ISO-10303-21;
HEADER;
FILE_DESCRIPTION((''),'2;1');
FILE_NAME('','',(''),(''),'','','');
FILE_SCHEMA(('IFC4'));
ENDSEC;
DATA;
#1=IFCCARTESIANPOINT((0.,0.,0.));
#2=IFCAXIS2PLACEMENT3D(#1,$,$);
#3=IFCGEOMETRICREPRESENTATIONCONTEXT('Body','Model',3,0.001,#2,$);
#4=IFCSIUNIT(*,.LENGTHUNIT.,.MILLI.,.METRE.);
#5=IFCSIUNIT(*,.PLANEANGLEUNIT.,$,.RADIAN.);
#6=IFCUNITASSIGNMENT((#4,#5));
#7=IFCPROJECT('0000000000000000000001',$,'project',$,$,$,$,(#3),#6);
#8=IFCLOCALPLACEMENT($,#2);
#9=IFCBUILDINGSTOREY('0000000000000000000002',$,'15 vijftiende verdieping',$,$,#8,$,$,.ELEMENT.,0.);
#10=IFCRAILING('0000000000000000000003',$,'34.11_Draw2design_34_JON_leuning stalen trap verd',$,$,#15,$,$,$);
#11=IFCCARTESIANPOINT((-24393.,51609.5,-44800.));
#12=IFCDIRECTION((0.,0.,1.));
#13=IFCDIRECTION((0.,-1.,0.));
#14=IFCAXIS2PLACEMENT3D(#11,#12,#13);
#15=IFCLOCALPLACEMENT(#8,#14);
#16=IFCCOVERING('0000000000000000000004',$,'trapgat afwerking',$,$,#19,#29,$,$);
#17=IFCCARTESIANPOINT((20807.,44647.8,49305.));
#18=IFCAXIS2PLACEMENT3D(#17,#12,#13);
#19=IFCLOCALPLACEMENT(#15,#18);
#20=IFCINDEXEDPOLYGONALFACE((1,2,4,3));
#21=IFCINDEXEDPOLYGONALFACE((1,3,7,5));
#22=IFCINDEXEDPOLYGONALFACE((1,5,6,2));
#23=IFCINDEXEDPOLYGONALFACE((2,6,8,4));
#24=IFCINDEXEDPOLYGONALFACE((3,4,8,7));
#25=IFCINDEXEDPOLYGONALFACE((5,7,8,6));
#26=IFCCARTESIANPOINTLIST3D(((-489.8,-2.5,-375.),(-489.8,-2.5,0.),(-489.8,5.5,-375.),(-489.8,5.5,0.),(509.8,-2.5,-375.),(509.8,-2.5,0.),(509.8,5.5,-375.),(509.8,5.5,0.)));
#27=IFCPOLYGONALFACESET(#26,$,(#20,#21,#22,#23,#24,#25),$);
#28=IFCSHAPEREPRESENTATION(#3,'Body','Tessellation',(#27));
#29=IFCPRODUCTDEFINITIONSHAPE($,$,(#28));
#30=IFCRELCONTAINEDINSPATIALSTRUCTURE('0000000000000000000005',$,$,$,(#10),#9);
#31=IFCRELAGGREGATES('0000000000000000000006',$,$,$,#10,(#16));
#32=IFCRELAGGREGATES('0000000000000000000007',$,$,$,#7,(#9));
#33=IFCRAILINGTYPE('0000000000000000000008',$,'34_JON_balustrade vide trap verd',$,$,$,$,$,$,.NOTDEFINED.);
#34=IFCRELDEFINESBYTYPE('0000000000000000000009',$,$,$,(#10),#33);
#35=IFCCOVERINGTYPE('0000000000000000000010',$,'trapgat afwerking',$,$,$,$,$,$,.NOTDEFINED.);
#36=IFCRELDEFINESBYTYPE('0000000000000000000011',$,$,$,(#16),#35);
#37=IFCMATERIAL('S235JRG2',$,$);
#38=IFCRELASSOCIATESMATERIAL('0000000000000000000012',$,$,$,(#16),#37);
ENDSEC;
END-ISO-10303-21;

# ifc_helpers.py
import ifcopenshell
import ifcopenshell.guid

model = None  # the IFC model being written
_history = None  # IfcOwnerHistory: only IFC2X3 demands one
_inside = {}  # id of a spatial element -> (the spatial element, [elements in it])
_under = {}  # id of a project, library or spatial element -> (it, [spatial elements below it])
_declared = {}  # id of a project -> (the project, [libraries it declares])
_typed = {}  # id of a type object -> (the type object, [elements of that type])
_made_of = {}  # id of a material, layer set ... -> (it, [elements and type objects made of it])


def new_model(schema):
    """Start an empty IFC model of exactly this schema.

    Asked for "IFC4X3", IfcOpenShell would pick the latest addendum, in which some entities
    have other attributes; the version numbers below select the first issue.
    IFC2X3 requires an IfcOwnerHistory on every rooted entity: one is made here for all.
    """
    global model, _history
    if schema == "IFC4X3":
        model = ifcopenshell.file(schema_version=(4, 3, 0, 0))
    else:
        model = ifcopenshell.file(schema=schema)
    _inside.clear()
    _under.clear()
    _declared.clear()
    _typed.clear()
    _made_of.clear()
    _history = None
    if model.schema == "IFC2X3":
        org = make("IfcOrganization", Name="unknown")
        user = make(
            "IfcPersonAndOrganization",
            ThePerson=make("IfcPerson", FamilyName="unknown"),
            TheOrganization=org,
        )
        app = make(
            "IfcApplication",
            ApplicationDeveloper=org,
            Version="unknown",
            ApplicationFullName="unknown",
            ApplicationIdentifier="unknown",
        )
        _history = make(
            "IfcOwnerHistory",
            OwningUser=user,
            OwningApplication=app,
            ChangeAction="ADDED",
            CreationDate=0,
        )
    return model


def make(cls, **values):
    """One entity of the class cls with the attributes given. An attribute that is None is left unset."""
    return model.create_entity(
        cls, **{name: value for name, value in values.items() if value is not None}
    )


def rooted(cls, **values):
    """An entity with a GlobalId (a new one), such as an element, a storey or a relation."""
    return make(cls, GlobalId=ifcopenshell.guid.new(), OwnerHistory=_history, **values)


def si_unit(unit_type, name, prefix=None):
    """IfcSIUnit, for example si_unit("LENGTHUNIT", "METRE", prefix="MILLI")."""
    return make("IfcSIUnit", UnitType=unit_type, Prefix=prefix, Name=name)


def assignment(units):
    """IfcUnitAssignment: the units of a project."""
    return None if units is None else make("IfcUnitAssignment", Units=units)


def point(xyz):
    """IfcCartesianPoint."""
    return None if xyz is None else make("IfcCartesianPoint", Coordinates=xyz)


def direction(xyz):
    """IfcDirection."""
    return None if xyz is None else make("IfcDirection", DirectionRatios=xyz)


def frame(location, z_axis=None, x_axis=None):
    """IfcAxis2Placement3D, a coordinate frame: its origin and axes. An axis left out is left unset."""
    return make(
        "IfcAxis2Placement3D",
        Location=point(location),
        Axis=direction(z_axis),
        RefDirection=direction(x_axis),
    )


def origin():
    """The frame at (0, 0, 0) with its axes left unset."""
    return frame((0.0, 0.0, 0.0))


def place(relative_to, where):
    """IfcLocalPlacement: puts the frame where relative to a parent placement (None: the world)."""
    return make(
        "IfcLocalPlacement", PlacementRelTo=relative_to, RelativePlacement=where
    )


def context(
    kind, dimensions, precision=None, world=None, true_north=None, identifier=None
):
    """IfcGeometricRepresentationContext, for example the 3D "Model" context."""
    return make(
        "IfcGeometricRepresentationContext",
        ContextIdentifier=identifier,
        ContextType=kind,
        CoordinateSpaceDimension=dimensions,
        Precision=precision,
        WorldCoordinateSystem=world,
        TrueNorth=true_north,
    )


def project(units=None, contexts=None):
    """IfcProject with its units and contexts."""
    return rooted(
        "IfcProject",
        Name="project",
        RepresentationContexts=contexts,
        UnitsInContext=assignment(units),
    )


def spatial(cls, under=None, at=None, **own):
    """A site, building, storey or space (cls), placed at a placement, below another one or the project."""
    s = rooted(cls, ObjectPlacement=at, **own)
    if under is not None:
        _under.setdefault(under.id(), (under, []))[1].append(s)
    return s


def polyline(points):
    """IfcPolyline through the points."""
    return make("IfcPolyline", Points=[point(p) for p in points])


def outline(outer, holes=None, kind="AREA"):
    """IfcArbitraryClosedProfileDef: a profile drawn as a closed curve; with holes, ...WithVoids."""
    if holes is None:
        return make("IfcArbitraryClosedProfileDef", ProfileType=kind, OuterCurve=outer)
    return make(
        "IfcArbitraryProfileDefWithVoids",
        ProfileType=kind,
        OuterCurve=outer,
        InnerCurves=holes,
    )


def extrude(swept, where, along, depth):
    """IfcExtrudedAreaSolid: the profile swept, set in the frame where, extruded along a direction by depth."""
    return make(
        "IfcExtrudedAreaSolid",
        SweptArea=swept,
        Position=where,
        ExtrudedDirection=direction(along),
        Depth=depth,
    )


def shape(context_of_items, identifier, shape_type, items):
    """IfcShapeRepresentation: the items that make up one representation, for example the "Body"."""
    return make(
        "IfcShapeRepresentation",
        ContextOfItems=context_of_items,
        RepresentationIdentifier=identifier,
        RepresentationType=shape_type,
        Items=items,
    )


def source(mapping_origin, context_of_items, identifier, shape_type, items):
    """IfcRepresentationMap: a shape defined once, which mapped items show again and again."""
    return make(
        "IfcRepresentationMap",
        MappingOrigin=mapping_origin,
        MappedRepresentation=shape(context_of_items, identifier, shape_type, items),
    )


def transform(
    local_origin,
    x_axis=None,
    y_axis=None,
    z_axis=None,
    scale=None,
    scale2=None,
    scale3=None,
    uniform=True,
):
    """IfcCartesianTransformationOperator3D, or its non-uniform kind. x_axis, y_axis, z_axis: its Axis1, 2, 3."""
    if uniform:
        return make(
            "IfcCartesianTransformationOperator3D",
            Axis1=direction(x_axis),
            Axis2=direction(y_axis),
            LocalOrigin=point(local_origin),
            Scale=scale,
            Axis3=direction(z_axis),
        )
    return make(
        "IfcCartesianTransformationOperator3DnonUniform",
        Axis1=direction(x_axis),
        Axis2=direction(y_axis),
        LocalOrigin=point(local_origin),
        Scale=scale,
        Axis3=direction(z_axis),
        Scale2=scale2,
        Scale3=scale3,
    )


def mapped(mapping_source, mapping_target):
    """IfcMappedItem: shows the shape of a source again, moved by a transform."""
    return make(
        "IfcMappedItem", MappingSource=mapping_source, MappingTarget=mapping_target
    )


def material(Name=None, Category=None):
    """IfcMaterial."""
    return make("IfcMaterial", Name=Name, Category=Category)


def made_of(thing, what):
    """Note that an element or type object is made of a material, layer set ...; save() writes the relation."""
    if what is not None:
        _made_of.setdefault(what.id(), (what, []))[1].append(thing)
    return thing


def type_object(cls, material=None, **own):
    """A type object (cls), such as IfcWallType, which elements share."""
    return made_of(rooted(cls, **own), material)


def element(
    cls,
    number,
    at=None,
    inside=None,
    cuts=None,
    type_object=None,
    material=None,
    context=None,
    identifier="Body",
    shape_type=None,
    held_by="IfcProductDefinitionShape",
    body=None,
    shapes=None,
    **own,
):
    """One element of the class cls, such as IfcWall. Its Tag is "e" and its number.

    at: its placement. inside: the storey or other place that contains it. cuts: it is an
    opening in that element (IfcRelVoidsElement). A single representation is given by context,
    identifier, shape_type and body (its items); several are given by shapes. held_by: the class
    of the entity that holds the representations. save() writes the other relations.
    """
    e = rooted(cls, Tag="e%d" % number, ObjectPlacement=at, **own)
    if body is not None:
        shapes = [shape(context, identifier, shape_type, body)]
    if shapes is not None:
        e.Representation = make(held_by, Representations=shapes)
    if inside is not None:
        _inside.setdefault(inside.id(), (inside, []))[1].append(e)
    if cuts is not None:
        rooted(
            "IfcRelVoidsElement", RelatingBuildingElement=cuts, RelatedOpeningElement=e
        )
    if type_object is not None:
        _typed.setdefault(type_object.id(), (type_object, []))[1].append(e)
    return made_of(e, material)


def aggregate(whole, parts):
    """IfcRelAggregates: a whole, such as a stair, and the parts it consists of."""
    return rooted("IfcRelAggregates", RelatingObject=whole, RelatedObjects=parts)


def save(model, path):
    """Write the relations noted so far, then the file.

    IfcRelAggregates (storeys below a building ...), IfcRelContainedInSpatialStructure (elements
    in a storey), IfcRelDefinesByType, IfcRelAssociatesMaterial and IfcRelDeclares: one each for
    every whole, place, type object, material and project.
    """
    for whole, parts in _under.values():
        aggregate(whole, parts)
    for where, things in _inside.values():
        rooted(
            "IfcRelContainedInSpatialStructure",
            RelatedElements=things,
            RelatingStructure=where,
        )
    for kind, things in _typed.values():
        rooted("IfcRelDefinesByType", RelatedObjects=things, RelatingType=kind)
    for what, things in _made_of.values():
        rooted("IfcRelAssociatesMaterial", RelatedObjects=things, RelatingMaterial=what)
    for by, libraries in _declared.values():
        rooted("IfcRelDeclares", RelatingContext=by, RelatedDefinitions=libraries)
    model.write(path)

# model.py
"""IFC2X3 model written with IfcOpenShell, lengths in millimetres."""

from ifc_helpers import new_model, si_unit, frame, origin, place, context, project, spatial, polyline, outline, extrude, source, transform, mapped, material, type_object, element, aggregate, save


model = new_model("IFC2X3")

# Units and contexts
model_context = context("Model", 3, precision=0.001, world=origin(), identifier="Body")
ifc_project = project(units=[si_unit("LENGTHUNIT", "METRE", prefix="MILLI"), si_unit("PLANEANGLEUNIT", "RADIAN")], contexts=[model_context])

# Storey
storey_placement = place(None, origin())
storey = spatial("IfcBuildingStorey", under=ifc_project, at=storey_placement, Name="15 vijftiende verdieping", CompositionType="ELEMENT", Elevation=0.0)

# Railing, covering
railing_type = type_object("IfcRailingType", Name="34_JON_balustrade vide trap verd")
railing_placement = place(storey_placement, frame((-24393.0, 51609.5, -44800.0), z_axis=(0.0, 0.0, 1.0), x_axis=(0.0, -1.0, 0.0)))
railing = element("IfcRailing", 1, at=railing_placement, inside=storey, type_object=railing_type, Name="34.11_Draw2design_34_JON_leuning stalen trap verd")
ifc_material_1 = material(Name="S235JRG2")
covering_type = type_object("IfcCoveringType", Name="trapgat afwerking")
shared_shape_1 = source(origin(), model_context, "Body", "SweptSolid", [
    extrude(outline(polyline([(-489.8, -2.5), (509.8, -2.5), (509.8, 5.5), (-489.8, 5.5), (-489.8, -2.5)])), origin(), (0.0, 0.0, -1.0), 375.0),
])
covering_placement = place(railing_placement, frame((20807.0, 44647.8, 49305.0), z_axis=(0.0, 0.0, 1.0), x_axis=(0.0, -1.0, 0.0)))
covering = element("IfcCovering", 2, at=covering_placement, type_object=covering_type, material=ifc_material_1, Name="trapgat afwerking", context=model_context, shape_type="MappedRepresentation", body=[
    mapped(shared_shape_1, transform((0.0, 0.0, 0.0), scale=1.0)),
])
aggregate(railing, [covering])

save(model, "model.ifc")
